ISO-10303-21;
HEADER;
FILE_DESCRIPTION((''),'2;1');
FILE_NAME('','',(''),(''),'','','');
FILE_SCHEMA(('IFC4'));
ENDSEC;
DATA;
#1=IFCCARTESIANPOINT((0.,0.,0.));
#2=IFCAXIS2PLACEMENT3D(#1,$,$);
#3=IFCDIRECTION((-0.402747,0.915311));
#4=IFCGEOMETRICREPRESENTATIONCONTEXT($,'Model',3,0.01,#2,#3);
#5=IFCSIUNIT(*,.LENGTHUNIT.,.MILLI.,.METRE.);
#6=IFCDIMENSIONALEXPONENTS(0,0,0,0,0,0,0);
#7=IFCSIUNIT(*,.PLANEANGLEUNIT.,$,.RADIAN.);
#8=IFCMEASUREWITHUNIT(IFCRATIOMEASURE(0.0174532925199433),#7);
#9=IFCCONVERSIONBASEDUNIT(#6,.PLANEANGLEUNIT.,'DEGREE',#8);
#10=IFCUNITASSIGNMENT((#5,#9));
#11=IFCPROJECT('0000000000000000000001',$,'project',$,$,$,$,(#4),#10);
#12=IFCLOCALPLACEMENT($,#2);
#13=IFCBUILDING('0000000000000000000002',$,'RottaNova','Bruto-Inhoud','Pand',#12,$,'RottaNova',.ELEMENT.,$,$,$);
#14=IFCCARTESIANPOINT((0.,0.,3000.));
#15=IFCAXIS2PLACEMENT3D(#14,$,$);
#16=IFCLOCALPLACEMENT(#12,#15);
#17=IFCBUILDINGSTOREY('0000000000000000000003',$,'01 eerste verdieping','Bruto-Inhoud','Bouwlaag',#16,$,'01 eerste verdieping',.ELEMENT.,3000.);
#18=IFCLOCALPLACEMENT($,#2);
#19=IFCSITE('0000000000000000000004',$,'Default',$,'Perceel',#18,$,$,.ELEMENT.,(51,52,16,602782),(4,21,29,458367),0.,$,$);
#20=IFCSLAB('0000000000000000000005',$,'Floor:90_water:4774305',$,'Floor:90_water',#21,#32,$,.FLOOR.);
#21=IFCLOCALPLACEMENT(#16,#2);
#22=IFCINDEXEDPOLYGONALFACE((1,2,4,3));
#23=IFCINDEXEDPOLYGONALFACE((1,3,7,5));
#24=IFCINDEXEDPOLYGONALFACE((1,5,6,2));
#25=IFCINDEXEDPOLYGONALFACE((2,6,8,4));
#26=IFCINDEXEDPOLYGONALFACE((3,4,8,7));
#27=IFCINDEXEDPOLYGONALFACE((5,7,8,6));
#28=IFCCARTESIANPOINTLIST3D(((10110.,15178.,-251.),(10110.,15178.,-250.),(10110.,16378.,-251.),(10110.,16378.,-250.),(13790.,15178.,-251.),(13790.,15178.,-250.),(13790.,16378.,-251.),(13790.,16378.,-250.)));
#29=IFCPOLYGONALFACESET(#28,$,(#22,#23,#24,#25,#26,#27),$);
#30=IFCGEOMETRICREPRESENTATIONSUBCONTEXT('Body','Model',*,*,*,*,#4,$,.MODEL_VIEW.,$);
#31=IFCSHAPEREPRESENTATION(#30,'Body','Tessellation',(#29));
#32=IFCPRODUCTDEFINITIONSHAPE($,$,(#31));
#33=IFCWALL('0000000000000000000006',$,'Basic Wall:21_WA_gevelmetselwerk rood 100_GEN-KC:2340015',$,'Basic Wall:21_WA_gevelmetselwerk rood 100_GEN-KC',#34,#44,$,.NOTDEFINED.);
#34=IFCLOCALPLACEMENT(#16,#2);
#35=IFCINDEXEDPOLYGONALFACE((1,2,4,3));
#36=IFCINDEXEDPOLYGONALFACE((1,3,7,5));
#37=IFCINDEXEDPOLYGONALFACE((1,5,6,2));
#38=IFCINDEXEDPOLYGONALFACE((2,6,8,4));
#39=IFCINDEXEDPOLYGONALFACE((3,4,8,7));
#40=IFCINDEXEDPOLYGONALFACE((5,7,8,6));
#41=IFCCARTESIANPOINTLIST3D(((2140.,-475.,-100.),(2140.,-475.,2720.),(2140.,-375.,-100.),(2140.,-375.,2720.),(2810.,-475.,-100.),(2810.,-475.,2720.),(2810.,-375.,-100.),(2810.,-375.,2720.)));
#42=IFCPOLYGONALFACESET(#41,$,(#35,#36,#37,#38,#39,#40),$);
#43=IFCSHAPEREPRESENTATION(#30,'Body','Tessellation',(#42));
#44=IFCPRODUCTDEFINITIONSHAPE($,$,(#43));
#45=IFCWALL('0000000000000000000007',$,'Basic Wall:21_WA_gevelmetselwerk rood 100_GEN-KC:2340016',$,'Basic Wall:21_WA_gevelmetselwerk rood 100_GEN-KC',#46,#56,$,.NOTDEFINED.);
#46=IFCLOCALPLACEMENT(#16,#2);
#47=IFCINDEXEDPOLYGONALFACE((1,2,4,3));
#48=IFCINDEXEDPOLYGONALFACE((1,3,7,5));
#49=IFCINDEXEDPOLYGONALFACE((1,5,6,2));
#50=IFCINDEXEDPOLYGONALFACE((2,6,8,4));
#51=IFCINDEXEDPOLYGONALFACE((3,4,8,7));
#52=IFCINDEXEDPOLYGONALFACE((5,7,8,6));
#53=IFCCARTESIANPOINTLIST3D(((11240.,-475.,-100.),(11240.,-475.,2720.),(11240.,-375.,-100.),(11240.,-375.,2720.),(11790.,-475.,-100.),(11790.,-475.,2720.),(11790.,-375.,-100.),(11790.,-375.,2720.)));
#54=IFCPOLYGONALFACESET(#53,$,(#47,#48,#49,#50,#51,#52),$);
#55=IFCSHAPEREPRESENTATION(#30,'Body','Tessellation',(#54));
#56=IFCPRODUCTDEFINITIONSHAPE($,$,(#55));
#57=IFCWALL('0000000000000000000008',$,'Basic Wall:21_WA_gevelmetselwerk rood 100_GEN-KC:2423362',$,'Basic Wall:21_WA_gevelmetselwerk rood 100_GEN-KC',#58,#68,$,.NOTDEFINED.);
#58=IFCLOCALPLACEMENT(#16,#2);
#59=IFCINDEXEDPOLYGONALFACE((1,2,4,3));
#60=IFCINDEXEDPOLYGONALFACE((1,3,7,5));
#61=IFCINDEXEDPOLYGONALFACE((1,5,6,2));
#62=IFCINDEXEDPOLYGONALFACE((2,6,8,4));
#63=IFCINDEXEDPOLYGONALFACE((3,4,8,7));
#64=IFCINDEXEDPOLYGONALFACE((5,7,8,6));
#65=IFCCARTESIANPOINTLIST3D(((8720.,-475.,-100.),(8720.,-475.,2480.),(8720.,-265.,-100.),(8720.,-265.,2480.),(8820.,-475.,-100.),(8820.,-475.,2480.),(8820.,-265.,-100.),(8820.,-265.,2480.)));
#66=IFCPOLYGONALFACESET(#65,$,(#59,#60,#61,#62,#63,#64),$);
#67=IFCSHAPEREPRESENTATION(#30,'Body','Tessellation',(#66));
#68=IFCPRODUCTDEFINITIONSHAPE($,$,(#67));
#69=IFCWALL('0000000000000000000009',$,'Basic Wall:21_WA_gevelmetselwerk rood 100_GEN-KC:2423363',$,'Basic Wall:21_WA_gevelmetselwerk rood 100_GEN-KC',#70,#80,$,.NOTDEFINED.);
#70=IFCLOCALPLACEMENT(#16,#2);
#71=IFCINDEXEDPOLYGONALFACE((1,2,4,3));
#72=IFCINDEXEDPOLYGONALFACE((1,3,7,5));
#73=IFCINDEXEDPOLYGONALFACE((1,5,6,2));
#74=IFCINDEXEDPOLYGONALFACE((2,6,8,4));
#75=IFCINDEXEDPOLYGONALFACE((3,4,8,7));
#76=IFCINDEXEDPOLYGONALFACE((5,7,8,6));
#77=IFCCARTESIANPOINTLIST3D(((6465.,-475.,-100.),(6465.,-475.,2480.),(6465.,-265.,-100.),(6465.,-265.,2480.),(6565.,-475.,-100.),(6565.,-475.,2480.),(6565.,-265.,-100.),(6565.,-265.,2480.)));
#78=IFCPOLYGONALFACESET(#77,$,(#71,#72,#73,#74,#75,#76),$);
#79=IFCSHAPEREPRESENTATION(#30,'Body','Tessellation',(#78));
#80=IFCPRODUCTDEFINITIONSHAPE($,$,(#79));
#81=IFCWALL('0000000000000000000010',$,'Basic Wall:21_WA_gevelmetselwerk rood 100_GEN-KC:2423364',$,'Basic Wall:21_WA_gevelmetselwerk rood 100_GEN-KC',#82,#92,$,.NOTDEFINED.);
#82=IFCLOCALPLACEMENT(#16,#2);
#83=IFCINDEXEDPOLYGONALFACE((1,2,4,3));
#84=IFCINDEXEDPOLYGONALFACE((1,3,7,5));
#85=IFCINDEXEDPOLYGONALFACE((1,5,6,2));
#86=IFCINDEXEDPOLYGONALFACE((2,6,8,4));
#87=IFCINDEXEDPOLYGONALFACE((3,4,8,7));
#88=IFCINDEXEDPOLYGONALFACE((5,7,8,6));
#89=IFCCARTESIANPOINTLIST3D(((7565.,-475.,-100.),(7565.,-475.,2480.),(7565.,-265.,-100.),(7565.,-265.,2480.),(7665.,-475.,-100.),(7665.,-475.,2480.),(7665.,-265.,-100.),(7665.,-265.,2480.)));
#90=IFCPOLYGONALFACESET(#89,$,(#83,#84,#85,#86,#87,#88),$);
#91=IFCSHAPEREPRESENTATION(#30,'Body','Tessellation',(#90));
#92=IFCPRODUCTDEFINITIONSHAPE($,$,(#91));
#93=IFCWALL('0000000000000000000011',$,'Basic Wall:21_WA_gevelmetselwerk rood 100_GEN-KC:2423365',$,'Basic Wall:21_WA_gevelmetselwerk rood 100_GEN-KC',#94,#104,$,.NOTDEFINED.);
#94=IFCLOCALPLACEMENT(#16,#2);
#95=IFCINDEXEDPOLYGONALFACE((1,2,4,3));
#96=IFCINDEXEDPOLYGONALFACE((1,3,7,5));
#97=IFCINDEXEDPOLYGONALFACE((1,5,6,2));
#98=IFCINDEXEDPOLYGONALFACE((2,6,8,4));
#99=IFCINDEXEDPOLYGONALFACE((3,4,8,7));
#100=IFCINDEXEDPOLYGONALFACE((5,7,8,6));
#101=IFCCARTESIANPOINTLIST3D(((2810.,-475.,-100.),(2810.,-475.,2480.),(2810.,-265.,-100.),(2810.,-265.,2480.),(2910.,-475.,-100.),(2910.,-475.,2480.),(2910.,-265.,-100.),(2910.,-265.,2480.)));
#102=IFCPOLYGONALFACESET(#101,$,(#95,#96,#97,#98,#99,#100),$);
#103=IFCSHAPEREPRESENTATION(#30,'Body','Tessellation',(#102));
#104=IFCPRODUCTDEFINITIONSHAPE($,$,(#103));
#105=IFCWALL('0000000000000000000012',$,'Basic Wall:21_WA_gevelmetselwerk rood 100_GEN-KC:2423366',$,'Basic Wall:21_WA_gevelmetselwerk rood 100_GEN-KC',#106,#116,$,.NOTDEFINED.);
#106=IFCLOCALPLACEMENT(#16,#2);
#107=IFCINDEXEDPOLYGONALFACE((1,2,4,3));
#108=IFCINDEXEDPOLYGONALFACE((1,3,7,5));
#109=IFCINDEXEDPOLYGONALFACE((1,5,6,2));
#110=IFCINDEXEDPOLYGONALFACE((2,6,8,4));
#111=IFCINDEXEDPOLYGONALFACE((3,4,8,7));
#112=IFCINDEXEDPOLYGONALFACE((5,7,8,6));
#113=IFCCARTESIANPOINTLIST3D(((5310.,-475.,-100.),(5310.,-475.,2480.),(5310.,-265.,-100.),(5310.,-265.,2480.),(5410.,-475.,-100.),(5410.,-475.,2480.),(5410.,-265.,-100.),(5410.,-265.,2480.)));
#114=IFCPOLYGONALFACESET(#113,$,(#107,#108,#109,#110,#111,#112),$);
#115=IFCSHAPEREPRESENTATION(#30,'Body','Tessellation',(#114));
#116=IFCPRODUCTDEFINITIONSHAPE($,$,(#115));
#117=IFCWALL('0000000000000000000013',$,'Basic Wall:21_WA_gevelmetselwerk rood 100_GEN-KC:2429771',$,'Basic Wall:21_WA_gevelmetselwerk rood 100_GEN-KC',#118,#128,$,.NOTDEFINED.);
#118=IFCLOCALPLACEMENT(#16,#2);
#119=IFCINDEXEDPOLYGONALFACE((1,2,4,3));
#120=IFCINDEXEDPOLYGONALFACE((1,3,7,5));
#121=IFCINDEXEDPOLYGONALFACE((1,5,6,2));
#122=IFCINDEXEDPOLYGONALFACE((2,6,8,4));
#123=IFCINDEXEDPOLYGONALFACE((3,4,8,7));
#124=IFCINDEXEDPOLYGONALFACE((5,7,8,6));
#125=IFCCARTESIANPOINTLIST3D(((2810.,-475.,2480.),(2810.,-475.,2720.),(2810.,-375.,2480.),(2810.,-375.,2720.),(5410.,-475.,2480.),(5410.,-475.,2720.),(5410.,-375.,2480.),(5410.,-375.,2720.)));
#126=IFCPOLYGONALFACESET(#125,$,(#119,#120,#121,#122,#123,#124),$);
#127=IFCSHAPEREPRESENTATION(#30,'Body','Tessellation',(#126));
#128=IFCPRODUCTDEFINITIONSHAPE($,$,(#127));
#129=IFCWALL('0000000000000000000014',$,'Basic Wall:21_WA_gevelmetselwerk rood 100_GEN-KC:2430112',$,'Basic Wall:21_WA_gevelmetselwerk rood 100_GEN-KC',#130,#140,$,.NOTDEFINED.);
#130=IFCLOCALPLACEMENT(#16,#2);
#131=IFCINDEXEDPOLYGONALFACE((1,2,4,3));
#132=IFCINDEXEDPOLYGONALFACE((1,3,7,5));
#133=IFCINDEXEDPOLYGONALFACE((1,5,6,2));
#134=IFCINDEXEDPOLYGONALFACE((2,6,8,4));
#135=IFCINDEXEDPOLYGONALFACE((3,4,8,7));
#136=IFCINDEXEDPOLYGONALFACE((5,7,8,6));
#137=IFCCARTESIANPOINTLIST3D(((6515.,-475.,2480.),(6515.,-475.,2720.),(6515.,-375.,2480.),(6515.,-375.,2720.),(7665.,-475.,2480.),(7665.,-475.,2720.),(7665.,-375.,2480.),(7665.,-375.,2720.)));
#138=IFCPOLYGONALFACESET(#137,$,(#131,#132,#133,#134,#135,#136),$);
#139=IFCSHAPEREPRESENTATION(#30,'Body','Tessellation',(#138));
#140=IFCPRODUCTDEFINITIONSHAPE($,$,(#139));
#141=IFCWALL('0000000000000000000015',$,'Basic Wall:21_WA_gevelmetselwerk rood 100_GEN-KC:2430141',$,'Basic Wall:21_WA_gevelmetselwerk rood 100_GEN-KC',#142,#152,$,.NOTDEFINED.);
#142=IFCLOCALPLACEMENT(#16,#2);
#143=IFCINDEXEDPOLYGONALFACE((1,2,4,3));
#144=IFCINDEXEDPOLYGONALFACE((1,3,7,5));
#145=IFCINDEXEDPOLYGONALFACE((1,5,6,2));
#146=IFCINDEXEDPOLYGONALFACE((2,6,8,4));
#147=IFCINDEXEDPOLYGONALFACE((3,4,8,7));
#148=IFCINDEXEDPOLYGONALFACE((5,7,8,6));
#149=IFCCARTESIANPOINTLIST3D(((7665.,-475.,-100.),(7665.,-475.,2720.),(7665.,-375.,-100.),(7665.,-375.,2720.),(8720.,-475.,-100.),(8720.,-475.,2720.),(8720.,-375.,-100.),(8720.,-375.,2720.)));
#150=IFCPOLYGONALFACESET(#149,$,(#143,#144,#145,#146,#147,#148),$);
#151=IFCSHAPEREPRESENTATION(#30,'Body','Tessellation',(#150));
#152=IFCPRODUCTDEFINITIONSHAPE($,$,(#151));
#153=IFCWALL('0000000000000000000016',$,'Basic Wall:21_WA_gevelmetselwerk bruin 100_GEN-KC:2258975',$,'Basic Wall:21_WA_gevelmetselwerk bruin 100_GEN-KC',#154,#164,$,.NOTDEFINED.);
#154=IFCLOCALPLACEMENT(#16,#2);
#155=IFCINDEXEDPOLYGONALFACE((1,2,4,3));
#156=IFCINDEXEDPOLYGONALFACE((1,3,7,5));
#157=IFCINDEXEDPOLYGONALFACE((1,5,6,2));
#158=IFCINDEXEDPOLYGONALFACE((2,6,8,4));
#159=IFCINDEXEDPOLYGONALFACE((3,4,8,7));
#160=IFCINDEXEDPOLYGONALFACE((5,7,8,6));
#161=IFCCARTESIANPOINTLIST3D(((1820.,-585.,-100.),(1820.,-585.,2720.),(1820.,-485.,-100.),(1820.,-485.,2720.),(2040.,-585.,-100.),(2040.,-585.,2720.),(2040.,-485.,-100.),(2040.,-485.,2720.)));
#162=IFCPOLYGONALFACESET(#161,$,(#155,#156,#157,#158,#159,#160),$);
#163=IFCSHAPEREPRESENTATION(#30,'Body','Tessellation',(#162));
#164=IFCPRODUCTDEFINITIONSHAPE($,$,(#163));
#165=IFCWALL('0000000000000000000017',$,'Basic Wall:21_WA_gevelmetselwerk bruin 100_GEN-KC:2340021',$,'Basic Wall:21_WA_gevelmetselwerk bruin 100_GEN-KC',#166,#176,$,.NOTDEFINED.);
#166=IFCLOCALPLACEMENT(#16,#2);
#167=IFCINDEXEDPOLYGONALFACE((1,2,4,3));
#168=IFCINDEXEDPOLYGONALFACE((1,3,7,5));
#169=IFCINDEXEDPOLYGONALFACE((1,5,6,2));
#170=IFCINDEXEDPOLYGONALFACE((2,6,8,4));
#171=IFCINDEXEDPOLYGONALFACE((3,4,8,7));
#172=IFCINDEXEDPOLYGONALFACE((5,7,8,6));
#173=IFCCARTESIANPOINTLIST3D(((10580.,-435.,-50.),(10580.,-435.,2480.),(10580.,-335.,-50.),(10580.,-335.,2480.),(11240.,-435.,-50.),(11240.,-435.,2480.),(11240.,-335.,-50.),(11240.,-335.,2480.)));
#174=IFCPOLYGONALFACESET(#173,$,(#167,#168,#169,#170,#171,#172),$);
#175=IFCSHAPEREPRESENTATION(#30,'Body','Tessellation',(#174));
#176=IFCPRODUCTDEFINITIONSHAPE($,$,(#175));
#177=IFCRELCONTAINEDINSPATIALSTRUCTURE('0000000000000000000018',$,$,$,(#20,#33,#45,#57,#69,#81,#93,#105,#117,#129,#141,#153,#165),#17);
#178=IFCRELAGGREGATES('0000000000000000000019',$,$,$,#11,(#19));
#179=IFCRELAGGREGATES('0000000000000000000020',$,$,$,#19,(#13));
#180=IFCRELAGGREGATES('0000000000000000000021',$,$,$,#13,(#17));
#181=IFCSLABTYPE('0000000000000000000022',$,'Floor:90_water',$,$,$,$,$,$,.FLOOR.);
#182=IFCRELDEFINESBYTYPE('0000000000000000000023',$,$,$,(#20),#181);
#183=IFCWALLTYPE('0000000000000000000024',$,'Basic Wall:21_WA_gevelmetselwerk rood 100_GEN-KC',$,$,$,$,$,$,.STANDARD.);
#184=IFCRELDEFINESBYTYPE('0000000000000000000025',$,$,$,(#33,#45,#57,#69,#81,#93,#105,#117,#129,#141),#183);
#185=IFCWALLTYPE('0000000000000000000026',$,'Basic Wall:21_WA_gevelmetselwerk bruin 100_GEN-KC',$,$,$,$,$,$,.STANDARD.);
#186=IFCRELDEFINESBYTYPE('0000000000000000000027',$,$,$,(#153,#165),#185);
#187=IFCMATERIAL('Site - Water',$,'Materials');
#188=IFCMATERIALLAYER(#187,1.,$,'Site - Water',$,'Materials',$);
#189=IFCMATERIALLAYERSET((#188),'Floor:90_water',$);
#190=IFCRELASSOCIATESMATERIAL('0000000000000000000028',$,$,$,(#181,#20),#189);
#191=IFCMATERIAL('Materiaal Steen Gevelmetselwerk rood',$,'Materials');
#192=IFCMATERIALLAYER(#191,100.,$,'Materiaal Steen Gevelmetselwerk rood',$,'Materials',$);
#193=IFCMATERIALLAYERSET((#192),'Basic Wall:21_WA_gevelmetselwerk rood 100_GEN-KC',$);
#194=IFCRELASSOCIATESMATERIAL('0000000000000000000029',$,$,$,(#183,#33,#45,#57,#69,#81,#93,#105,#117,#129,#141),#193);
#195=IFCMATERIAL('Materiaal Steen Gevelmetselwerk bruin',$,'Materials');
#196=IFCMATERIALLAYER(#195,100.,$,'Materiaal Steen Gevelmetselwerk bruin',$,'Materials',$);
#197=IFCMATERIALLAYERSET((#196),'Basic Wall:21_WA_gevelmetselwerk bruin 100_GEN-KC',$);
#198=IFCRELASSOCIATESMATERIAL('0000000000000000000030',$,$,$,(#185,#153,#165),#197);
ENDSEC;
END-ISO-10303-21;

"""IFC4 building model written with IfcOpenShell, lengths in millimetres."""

from ifc_helpers import new_model, entity, si_unit, converted_unit, direction, frame, frame_2d, origin, place, context, subcontext, project, spatial, polyline, rectangle, extrude, clip, bounded_halfspace, material, layer, layer_set, layer_usage, type_object, element, save


model = new_model("IFC4")

# Units and contexts
model_context = context("Model", 3, precision=0.01, world=origin(), true_north=direction((-0.402747, 0.915311)))
body_context = subcontext(model_context, "Body", "Model", "MODEL_VIEW")
ifc_project = project(units=[si_unit("LENGTHUNIT", "METRE", prefix="MILLI"), converted_unit("PLANEANGLEUNIT", "DEGREE", entity("IfcRatioMeasure", 0.0174532925199433), si_unit("PLANEANGLEUNIT", "RADIAN"), dimensions=[0, 0, 0, 0, 0, 0, 0])], contexts=[model_context])

# Site, building, storey
site_placement = place(None, origin())
site = spatial("IfcSite", under=ifc_project, at=site_placement, Name="Default", ObjectType="Perceel", CompositionType="ELEMENT", RefLatitude=(51, 52, 16, 602782), RefLongitude=(4, 21, 29, 458367), RefElevation=0.0)
building_placement = place(None, origin())
building = spatial("IfcBuilding", under=site, at=building_placement, Name="RottaNova", Description="Bruto-Inhoud", ObjectType="Pand", LongName="RottaNova", CompositionType="ELEMENT")
storey_placement = place(building_placement, frame((0.0, 0.0, 3000.0)))
storey = spatial("IfcBuildingStorey", under=building, at=storey_placement, Name="01 eerste verdieping", Description="Bruto-Inhoud", ObjectType="Bouwlaag", LongName="01 eerste verdieping", CompositionType="ELEMENT", Elevation=3000.0)

# Slab
ifc_material_1 = material(Name="Site - Water", Category="Materials")
ifc_layer_1 = layer(ifc_material_1, 1.0, Name="Site - Water", Category="Materials")
ifc_layer_set_1 = layer_set([ifc_layer_1], Name="Floor:90_water")
ifc_layer_usage_1 = layer_usage(ifc_layer_set_1, "AXIS3", "POSITIVE", 0.0)
slab_type_1 = type_object("IfcSlabType", Name="Floor:90_water", PredefinedType="FLOOR", material=ifc_layer_set_1)
slab_1_placement = place(storey_placement, origin())
element("IfcSlab", 1, at=slab_1_placement, inside=storey, type_object=slab_type_1, material=ifc_layer_usage_1, Name="Floor:90_water:4774305", ObjectType="Floor:90_water", PredefinedType="FLOOR", context=body_context, shape_type="SweptSolid", body=[
    extrude(rectangle(XDim=1200.0, YDim=3680.0, at=frame_2d((0.0, 0.0), x_axis=(1.0, 0.0))), frame((11950.0, 15778.0, -250.0), z_axis=(0.0, 0.0, -1.0), x_axis=(0.0, 1.0, 0.0)), (0.0, 0.0, 1.0), 1.0),
])

# Walls
ifc_material_2 = material(Name="Materiaal Steen Gevelmetselwerk rood", Category="Materials")
ifc_layer_2 = layer(ifc_material_2, 100.0, Name="Materiaal Steen Gevelmetselwerk rood", Category="Materials")
ifc_layer_set_2 = layer_set([ifc_layer_2], Name="Basic Wall:21_WA_gevelmetselwerk rood 100_GEN-KC")
wall_type_1 = type_object("IfcWallType", Name="Basic Wall:21_WA_gevelmetselwerk rood 100_GEN-KC", PredefinedType="STANDARD", material=ifc_layer_set_2)
wall_1_placement = place(storey_placement, frame((2140.0, -425.0, -100.0)))
element("IfcWall", 2, at=wall_1_placement, inside=storey, type_object=wall_type_1, material=ifc_layer_set_2, Name="Basic Wall:21_WA_gevelmetselwerk rood 100_GEN-KC:2340015", ObjectType="Basic Wall:21_WA_gevelmetselwerk rood 100_GEN-KC", PredefinedType="NOTDEFINED", context=body_context, shape_type="SweptSolid", body=[
    extrude(rectangle(XDim=670.0, YDim=100.0, at=frame_2d((335.0, 0.0), x_axis=(-1.0, 0.0))), origin(), (0.0, 0.0, 1.0), 2820.0),
])
wall_2_placement = place(storey_placement, frame((11240.0, -425.0, -100.0)))
element("IfcWall", 3, at=wall_2_placement, inside=storey, type_object=wall_type_1, material=ifc_layer_set_2, Name="Basic Wall:21_WA_gevelmetselwerk rood 100_GEN-KC:2340016", ObjectType="Basic Wall:21_WA_gevelmetselwerk rood 100_GEN-KC", PredefinedType="NOTDEFINED", context=body_context, shape_type="SweptSolid", body=[
    extrude(rectangle(XDim=550.0, YDim=100.0, at=frame_2d((275.0, 0.0), x_axis=(-1.0, 0.0))), origin(), (0.0, 0.0, 1.0), 2820.0),
])
wall_3_placement = place(storey_placement, frame((8770.0, -265.0, -100.0), z_axis=(0.0, 0.0, 1.0), x_axis=(0.0, -1.0, 0.0)))
element("IfcWall", 4, at=wall_3_placement, inside=storey, type_object=wall_type_1, material=ifc_layer_set_2, Name="Basic Wall:21_WA_gevelmetselwerk rood 100_GEN-KC:2423362", ObjectType="Basic Wall:21_WA_gevelmetselwerk rood 100_GEN-KC", PredefinedType="NOTDEFINED", context=body_context, shape_type="SweptSolid", body=[
    extrude(rectangle(XDim=210.0, YDim=100.0, at=frame_2d((105.0, 0.0), x_axis=(-1.0, 0.0))), origin(), (0.0, 0.0, 1.0), 2580.0),
])
for number, where, z_axis, x_axis, name in (
    (5, (6515.0, -265.0, -100.0), (0.0, 0.0, 1.0), (0.0, -1.0, 0.0), "Basic Wall:21_WA_gevelmetselwerk rood 100_GEN-KC:2423363"),
    (6, (7615.0, -265.0, -100.0), (0.0, 0.0, 1.0), (0.0, -1.0, 0.0), "Basic Wall:21_WA_gevelmetselwerk rood 100_GEN-KC:2423364"),
):
    element("IfcWall", number, at=place(storey_placement, frame(where, z_axis=z_axis, x_axis=x_axis)), inside=storey, type_object=wall_type_1, material=ifc_layer_set_2, Name=name, ObjectType="Basic Wall:21_WA_gevelmetselwerk rood 100_GEN-KC", PredefinedType="NOTDEFINED", context=body_context, shape_type="SweptSolid", body=[
        extrude(rectangle(XDim=210.0, YDim=100.0, at=frame_2d((105.0, 0.0), x_axis=(-1.0, 0.0))), origin(), (0.0, 0.0, 1.0), 2580.0),
    ])
wall_4_placement = place(storey_placement, frame((2860.0, -265.0, -100.0), z_axis=(0.0, 0.0, 1.0), x_axis=(0.0, -1.0, 0.0)))
element("IfcWall", 7, at=wall_4_placement, inside=storey, type_object=wall_type_1, material=ifc_layer_set_2, Name="Basic Wall:21_WA_gevelmetselwerk rood 100_GEN-KC:2423365", ObjectType="Basic Wall:21_WA_gevelmetselwerk rood 100_GEN-KC", PredefinedType="NOTDEFINED", context=body_context, shape_type="SweptSolid", body=[
    extrude(rectangle(XDim=210.0, YDim=100.0, at=frame_2d((105.0, 0.0), x_axis=(-1.0, 0.0))), origin(), (0.0, 0.0, 1.0), 2580.0),
])
wall_5_placement = place(storey_placement, frame((5360.0, -265.0, -100.0), z_axis=(0.0, 0.0, 1.0), x_axis=(0.0, -1.0, 0.0)))
element("IfcWall", 8, at=wall_5_placement, inside=storey, type_object=wall_type_1, material=ifc_layer_set_2, Name="Basic Wall:21_WA_gevelmetselwerk rood 100_GEN-KC:2423366", ObjectType="Basic Wall:21_WA_gevelmetselwerk rood 100_GEN-KC", PredefinedType="NOTDEFINED", context=body_context, shape_type="SweptSolid", body=[
    extrude(rectangle(XDim=210.0, YDim=100.0, at=frame_2d((105.0, 0.0), x_axis=(-1.0, 0.0))), origin(), (0.0, 0.0, 1.0), 2580.0),
])
wall_6_placement = place(storey_placement, frame((2810.0, -425.0, 2480.0)))
element("IfcWall", 9, at=wall_6_placement, inside=storey, type_object=wall_type_1, material=ifc_layer_set_2, Name="Basic Wall:21_WA_gevelmetselwerk rood 100_GEN-KC:2429771", ObjectType="Basic Wall:21_WA_gevelmetselwerk rood 100_GEN-KC", PredefinedType="NOTDEFINED", context=body_context, shape_type="Clipping", body=[
    clip(extrude(rectangle(XDim=2600.0, YDim=100.0, at=frame_2d((1300.0, 0.0), x_axis=(-1.0, 0.0))), origin(), (0.0, 0.0, 1.0), 240.0), bounded_halfspace(frame((2600.0, -50.0, 240.0), z_axis=(1.0, 0.0, 0.0), x_axis=(0.0, 1.0, 0.0)), False, frame((2600.0, -50.0, 240.0), z_axis=(1.0, 0.0, 0.0), x_axis=(0.0, 1.0, 0.0)), polyline([(0.0, 0.0), (0.0, -73152.0), (30480.0, -73152.0), (30480.0, 0.0), (0.0, 0.0)]))),
])
wall_7_placement = place(storey_placement, frame((6515.0, -425.0, 2480.0)))
element("IfcWall", 10, at=wall_7_placement, inside=storey, type_object=wall_type_1, material=ifc_layer_set_2, Name="Basic Wall:21_WA_gevelmetselwerk rood 100_GEN-KC:2430112", ObjectType="Basic Wall:21_WA_gevelmetselwerk rood 100_GEN-KC", PredefinedType="NOTDEFINED", context=body_context, shape_type="SweptSolid", body=[
    extrude(rectangle(XDim=1150.0, YDim=100.0, at=frame_2d((575.0, 0.0), x_axis=(-1.0, 0.0))), origin(), (0.0, 0.0, 1.0), 240.0),
])
wall_8_placement = place(storey_placement, frame((7665.0, -425.0, -100.0)))
element("IfcWall", 11, at=wall_8_placement, inside=storey, type_object=wall_type_1, material=ifc_layer_set_2, Name="Basic Wall:21_WA_gevelmetselwerk rood 100_GEN-KC:2430141", ObjectType="Basic Wall:21_WA_gevelmetselwerk rood 100_GEN-KC", PredefinedType="NOTDEFINED", context=body_context, shape_type="SweptSolid", body=[
    extrude(rectangle(XDim=1055.0, YDim=100.0, at=frame_2d((527.5, 0.0), x_axis=(-1.0, 0.0))), origin(), (0.0, 0.0, 1.0), 2820.0),
])
ifc_material_3 = material(Name="Materiaal Steen Gevelmetselwerk bruin", Category="Materials")
ifc_layer_3 = layer(ifc_material_3, 100.0, Name="Materiaal Steen Gevelmetselwerk bruin", Category="Materials")
ifc_layer_set_3 = layer_set([ifc_layer_3], Name="Basic Wall:21_WA_gevelmetselwerk bruin 100_GEN-KC")
wall_type_2 = type_object("IfcWallType", Name="Basic Wall:21_WA_gevelmetselwerk bruin 100_GEN-KC", PredefinedType="STANDARD", material=ifc_layer_set_3)
wall_9_placement = place(storey_placement, frame((1820.0, -535.0, -100.0)))
element("IfcWall", 12, at=wall_9_placement, inside=storey, type_object=wall_type_2, material=ifc_layer_set_3, Name="Basic Wall:21_WA_gevelmetselwerk bruin 100_GEN-KC:2258975", ObjectType="Basic Wall:21_WA_gevelmetselwerk bruin 100_GEN-KC", PredefinedType="NOTDEFINED", context=body_context, shape_type="SweptSolid", body=[
    extrude(rectangle(XDim=220.0, YDim=100.0, at=frame_2d((110.0, 0.0), x_axis=(-1.0, 0.0))), origin(), (0.0, 0.0, 1.0), 2820.0),
])
wall_10_placement = place(storey_placement, frame((11240.0, -385.0, -50.0), z_axis=(0.0, 0.0, 1.0), x_axis=(-1.0, 0.0, 0.0)))
element("IfcWall", 13, at=wall_10_placement, inside=storey, type_object=wall_type_2, material=ifc_layer_set_3, Name="Basic Wall:21_WA_gevelmetselwerk bruin 100_GEN-KC:2340021", ObjectType="Basic Wall:21_WA_gevelmetselwerk bruin 100_GEN-KC", PredefinedType="NOTDEFINED", context=body_context, shape_type="SweptSolid", body=[
    extrude(rectangle(XDim=660.0, YDim=100.0, at=frame_2d((330.0, 0.0), x_axis=(-1.0, 0.0))), origin(), (0.0, 0.0, 1.0), 2530.0),
])

save(model, "model.ifc")
